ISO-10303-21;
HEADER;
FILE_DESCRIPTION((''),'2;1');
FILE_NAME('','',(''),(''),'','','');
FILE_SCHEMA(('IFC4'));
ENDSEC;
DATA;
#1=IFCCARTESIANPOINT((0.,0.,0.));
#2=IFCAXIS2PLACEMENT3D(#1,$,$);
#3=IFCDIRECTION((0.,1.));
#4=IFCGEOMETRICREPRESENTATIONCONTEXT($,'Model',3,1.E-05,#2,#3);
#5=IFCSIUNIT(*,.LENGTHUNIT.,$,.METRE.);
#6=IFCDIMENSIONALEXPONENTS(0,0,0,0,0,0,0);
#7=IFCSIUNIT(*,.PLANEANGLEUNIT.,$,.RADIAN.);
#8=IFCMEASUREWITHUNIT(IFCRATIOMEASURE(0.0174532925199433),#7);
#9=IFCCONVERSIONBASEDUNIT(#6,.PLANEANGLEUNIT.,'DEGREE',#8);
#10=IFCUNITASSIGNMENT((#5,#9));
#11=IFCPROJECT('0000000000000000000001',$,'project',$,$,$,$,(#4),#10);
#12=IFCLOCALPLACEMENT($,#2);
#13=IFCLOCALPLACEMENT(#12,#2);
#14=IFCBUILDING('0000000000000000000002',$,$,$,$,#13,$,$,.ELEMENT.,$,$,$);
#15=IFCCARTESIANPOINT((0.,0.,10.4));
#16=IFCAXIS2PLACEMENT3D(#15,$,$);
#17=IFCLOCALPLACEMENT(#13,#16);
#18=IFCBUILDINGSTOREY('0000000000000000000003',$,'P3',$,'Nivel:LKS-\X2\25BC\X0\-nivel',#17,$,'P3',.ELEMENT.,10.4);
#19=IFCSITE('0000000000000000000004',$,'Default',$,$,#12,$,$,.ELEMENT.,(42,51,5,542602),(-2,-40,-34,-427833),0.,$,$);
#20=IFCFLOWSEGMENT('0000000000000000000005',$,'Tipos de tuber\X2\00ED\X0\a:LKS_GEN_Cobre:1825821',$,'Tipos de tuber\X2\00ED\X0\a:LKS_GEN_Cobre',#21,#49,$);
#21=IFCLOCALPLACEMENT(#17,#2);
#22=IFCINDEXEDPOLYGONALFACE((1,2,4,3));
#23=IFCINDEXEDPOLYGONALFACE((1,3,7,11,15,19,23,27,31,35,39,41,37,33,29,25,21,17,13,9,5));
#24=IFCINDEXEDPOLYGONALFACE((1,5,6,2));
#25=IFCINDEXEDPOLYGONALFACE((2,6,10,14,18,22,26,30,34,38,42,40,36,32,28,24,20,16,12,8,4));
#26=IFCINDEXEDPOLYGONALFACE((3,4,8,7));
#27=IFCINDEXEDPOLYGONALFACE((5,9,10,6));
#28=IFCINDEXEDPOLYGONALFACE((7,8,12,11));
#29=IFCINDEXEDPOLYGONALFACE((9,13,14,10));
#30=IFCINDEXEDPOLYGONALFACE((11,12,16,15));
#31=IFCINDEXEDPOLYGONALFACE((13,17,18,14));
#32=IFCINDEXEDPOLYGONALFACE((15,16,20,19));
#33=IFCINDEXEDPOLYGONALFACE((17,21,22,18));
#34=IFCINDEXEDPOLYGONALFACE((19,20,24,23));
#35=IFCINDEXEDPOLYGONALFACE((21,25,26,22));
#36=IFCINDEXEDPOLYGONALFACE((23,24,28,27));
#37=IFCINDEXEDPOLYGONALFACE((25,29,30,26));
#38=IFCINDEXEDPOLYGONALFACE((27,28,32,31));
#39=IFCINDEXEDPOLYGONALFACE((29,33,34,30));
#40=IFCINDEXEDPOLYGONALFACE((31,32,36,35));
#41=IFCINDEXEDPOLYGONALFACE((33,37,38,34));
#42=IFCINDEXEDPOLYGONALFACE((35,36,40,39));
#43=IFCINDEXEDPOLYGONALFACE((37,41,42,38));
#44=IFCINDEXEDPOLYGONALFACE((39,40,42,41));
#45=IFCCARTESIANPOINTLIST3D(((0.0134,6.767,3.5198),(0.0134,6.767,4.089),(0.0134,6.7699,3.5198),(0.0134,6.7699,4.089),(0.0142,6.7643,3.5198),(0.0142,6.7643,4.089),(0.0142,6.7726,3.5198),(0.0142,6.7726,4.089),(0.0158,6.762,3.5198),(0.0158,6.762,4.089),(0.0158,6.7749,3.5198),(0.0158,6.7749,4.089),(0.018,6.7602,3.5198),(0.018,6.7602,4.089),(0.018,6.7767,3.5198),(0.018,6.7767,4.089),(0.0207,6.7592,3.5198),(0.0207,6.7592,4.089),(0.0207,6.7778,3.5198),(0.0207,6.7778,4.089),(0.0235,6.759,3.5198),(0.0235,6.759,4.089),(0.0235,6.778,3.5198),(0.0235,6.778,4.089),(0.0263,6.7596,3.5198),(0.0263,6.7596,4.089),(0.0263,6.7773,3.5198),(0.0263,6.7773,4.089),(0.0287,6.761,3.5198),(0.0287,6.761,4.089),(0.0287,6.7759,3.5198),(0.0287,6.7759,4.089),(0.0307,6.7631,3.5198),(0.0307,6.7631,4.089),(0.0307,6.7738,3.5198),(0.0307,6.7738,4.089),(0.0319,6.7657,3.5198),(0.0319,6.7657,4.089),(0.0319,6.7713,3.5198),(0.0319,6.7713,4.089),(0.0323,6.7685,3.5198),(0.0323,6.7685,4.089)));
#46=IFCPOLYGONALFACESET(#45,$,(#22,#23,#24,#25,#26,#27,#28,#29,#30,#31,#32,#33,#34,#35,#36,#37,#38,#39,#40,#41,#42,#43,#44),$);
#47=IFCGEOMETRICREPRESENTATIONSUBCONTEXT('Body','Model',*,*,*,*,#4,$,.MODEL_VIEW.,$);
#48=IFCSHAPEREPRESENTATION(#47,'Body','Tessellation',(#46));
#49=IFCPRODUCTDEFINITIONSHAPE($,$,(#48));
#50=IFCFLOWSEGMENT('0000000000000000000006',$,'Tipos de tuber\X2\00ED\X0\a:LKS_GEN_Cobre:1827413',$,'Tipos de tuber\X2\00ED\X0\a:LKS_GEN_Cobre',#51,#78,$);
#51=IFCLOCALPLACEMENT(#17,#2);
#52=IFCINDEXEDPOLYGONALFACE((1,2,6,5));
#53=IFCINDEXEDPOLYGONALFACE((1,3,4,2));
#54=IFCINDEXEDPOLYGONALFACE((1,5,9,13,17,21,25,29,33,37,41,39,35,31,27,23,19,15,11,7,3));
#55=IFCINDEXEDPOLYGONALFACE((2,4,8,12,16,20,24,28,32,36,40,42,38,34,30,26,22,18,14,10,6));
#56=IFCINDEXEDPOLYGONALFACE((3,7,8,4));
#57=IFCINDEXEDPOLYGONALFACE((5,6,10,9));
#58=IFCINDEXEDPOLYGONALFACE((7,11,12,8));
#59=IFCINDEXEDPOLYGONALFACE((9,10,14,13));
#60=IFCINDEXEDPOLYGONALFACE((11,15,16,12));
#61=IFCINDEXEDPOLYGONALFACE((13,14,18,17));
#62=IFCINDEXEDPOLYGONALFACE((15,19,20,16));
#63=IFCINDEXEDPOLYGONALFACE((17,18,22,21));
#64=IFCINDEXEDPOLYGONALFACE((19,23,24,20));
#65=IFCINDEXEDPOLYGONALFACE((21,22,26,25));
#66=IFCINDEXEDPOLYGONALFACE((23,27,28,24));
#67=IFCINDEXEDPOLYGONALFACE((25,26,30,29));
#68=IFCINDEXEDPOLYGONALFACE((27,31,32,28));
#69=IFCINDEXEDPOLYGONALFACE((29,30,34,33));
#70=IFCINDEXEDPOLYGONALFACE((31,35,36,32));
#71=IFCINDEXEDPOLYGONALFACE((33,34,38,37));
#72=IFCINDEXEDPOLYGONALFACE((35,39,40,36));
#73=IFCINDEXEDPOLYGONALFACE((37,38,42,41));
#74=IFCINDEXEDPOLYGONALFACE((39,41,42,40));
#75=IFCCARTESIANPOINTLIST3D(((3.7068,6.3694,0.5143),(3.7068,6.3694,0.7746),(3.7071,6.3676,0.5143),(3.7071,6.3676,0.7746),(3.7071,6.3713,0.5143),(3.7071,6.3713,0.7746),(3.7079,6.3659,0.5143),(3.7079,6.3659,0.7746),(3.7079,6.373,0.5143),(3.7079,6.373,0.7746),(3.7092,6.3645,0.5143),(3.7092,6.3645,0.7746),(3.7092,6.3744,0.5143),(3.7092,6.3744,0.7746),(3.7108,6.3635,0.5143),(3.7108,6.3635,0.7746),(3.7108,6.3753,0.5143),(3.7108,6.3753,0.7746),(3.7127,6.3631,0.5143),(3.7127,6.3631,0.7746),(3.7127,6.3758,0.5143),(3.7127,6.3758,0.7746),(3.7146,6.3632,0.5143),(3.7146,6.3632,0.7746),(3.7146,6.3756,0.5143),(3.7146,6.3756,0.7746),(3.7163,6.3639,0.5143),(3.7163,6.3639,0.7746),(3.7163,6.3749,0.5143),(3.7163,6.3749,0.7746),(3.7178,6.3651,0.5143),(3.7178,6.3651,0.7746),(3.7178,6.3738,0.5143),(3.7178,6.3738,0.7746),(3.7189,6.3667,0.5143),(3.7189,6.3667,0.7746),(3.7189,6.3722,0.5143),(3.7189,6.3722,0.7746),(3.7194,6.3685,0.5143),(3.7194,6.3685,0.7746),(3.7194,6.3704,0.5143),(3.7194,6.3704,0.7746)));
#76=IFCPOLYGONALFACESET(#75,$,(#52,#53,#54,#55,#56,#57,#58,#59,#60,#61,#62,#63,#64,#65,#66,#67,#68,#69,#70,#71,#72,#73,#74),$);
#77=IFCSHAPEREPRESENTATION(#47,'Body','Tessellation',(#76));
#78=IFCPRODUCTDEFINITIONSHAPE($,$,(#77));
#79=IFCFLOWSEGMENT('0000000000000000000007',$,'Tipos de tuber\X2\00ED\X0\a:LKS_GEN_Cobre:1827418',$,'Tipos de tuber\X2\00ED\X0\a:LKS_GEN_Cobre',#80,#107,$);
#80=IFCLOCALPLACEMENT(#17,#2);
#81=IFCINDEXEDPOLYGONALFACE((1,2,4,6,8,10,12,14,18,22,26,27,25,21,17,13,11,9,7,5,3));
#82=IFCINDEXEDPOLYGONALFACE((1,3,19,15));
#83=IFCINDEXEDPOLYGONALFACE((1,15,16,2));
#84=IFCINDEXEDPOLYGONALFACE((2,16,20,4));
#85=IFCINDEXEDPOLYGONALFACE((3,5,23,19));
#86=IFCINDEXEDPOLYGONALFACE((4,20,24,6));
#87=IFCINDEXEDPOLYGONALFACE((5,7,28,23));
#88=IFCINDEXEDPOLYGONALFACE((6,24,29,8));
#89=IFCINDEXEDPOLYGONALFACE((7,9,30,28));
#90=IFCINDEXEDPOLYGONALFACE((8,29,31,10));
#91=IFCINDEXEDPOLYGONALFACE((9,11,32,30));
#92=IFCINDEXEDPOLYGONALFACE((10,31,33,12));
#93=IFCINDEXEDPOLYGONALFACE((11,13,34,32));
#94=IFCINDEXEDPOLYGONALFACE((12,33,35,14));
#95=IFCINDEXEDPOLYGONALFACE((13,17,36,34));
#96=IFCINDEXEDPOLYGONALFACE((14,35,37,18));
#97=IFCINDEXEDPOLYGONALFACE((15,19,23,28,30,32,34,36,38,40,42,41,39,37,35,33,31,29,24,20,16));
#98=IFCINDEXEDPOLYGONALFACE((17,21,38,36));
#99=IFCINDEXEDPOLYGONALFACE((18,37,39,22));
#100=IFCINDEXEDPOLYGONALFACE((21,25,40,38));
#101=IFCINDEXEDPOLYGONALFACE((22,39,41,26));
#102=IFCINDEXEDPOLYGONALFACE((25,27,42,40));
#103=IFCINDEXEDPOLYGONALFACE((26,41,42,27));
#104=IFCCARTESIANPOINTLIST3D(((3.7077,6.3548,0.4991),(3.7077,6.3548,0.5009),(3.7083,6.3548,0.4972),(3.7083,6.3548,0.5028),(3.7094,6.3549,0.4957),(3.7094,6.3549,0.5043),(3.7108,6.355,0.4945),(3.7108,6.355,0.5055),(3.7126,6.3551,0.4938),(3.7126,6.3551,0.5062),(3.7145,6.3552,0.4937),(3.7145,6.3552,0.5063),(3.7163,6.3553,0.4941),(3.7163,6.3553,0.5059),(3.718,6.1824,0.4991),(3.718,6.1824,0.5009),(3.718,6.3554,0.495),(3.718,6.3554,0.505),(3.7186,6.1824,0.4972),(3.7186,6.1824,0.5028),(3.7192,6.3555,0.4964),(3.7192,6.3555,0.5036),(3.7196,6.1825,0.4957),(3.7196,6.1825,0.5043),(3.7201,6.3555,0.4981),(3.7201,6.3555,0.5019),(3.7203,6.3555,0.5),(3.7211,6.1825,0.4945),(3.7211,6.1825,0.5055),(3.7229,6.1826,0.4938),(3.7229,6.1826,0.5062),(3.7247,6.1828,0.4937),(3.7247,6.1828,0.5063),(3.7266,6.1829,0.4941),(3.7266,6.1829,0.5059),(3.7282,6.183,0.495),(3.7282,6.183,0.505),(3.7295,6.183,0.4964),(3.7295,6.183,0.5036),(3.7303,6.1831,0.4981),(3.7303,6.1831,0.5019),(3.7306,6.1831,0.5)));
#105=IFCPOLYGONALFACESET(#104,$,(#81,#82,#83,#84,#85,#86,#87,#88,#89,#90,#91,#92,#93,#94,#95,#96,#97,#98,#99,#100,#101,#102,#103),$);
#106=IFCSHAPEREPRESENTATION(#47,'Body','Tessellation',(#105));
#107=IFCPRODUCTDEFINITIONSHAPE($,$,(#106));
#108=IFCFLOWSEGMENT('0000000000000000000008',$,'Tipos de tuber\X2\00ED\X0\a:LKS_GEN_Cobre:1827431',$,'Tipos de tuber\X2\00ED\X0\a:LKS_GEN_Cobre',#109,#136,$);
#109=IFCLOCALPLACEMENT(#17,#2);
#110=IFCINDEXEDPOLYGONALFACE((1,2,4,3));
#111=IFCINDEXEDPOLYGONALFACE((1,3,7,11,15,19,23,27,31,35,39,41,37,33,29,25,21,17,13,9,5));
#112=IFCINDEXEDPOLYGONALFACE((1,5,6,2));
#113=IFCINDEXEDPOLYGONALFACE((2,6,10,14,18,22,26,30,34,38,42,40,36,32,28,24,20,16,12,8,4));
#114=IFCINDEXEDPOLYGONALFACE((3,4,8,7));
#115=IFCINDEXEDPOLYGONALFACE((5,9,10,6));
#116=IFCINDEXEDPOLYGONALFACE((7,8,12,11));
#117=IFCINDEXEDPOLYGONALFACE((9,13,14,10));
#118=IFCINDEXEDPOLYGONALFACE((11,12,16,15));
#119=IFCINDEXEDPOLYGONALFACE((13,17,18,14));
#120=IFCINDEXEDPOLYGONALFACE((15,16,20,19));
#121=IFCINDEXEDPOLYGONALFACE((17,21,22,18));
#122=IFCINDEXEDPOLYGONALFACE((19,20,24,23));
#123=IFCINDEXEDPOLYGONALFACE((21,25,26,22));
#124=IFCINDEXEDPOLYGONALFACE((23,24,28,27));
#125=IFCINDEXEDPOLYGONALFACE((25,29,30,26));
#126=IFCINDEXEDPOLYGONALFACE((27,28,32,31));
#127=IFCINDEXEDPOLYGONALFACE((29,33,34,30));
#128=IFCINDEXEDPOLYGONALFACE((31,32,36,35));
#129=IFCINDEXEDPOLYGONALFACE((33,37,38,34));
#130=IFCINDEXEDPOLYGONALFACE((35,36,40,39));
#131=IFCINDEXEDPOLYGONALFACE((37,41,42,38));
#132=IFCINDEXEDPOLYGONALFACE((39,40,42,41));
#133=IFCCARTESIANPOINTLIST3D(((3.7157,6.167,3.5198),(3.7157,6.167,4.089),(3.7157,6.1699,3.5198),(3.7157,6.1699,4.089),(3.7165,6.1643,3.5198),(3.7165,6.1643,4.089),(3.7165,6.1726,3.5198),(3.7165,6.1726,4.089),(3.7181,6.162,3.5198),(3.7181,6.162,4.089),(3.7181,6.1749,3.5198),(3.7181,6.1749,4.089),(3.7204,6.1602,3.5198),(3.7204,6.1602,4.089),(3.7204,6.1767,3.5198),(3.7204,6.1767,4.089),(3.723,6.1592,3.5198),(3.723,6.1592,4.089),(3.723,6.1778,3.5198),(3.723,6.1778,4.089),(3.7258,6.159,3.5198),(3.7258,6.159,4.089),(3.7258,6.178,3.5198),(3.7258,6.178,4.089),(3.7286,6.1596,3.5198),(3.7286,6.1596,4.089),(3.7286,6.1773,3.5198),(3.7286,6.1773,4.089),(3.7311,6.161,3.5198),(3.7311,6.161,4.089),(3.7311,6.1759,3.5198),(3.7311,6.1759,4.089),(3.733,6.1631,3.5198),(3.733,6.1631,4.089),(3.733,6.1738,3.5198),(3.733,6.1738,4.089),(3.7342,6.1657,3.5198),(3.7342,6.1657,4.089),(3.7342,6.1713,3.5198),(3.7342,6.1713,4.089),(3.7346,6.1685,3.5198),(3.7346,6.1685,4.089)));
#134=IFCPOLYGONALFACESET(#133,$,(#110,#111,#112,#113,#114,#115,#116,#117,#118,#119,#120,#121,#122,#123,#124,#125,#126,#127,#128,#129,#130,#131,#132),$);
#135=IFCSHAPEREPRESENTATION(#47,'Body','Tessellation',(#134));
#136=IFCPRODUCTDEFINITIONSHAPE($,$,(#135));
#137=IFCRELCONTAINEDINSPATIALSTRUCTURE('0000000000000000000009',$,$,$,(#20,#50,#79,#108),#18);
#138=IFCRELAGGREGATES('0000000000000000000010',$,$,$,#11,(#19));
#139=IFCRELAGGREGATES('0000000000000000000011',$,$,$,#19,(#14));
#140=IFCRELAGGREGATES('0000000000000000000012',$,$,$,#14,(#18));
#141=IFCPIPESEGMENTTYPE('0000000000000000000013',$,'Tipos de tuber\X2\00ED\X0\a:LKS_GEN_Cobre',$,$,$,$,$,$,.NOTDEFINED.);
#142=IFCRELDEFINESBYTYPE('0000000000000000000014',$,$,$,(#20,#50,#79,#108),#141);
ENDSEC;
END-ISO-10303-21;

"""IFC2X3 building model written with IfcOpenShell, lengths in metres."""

from ifc_helpers import new_model, entity, si_unit, converted_unit, direction, frame, frame_2d, origin, origin_2d_with_axis, place, context, subcontext, project, spatial, circle, extrude, type_object, element, save


model = new_model("IFC2X3")

# Units and contexts
model_context = context("Model", 3, precision=1e-05, world=origin(), true_north=direction((0.0, 1.0)))
body_context = subcontext(model_context, "Body", "Model", "MODEL_VIEW")
ifc_project = project(units=[si_unit("LENGTHUNIT", "METRE"), converted_unit("PLANEANGLEUNIT", "DEGREE", entity("IfcRatioMeasure", 0.0174532925199433), si_unit("PLANEANGLEUNIT", "RADIAN"), dimensions=[0, 0, 0, 0, 0, 0, 0])], contexts=[model_context])

# Site, building, storey
site_placement = place(None, origin())
site = spatial("IfcSite", under=ifc_project, at=site_placement, Name="Default", CompositionType="ELEMENT", RefLatitude=(42, 51, 5, 542602), RefLongitude=(-2, -40, -34, -427833), RefElevation=0.0)
building_placement = place(site_placement, origin())
building = spatial("IfcBuilding", under=site, at=building_placement, CompositionType="ELEMENT")
storey_placement = place(building_placement, frame((0.0, 0.0, 10.4)))
storey = spatial("IfcBuildingStorey", under=building, at=storey_placement, Name="P3", ObjectType="Nivel:LKS-▼-nivel", LongName="P3", CompositionType="ELEMENT", Elevation=10.4)

# Flow segments
pipe_segment_type = type_object("IfcPipeSegmentType", Name="Tipos de tubería:LKS_GEN_Cobre", PredefinedType="NOTDEFINED")
flow_segment_1_placement = place(storey_placement, origin())
element("IfcFlowSegment", 1, at=flow_segment_1_placement, inside=storey, type_object=pipe_segment_type, Name="Tipos de tubería:LKS_GEN_Cobre:1825821", ObjectType="Tipos de tubería:LKS_GEN_Cobre", context=body_context, shape_type="SweptSolid", body=[
    extrude(circle(Radius=0.0095, at=frame_2d((0.0, 0.0), x_axis=(1.0, 0.0))), frame((0.0228, 6.7685, 3.5198)), (0.0, 0.0, 1.0), 0.5692),
])
flow_segment_2_placement = place(storey_placement, origin())
element("IfcFlowSegment", 2, at=flow_segment_2_placement, inside=storey, type_object=pipe_segment_type, Name="Tipos de tubería:LKS_GEN_Cobre:1827413", ObjectType="Tipos de tubería:LKS_GEN_Cobre", context=body_context, shape_type="SweptSolid", body=[
    extrude(circle(Radius=0.0063, at=origin_2d_with_axis()), frame((3.7132, 6.3694, 0.5143), z_axis=(0.0, 0.0, 1.0), x_axis=(-1.0, 0.0, 0.0)), (0.0, 0.0, 1.0), 0.2603),
])
flow_segment_3_placement = place(storey_placement, origin())
element("IfcFlowSegment", 3, at=flow_segment_3_placement, inside=storey, type_object=pipe_segment_type, Name="Tipos de tubería:LKS_GEN_Cobre:1827418", ObjectType="Tipos de tubería:LKS_GEN_Cobre", context=body_context, shape_type="SweptSolid", body=[
    extrude(circle(Radius=0.0063, at=origin_2d_with_axis()), frame((3.7243, 6.1827, 0.5), z_axis=(-0.059398, 0.998234, 0.0), x_axis=(0.998234, 0.059398, 0.0)), (0.0, 0.0, 1.0), 0.1727),
])
flow_segment_4_placement = place(storey_placement, origin())
element("IfcFlowSegment", 4, at=flow_segment_4_placement, inside=storey, type_object=pipe_segment_type, Name="Tipos de tubería:LKS_GEN_Cobre:1827431", ObjectType="Tipos de tubería:LKS_GEN_Cobre", context=body_context, shape_type="SweptSolid", body=[
    extrude(circle(Radius=0.0095, at=origin_2d_with_axis()), frame((3.7251, 6.1685, 3.5198)), (0.0, 0.0, 1.0), 0.5692),
])

save(model, "model.ifc")
